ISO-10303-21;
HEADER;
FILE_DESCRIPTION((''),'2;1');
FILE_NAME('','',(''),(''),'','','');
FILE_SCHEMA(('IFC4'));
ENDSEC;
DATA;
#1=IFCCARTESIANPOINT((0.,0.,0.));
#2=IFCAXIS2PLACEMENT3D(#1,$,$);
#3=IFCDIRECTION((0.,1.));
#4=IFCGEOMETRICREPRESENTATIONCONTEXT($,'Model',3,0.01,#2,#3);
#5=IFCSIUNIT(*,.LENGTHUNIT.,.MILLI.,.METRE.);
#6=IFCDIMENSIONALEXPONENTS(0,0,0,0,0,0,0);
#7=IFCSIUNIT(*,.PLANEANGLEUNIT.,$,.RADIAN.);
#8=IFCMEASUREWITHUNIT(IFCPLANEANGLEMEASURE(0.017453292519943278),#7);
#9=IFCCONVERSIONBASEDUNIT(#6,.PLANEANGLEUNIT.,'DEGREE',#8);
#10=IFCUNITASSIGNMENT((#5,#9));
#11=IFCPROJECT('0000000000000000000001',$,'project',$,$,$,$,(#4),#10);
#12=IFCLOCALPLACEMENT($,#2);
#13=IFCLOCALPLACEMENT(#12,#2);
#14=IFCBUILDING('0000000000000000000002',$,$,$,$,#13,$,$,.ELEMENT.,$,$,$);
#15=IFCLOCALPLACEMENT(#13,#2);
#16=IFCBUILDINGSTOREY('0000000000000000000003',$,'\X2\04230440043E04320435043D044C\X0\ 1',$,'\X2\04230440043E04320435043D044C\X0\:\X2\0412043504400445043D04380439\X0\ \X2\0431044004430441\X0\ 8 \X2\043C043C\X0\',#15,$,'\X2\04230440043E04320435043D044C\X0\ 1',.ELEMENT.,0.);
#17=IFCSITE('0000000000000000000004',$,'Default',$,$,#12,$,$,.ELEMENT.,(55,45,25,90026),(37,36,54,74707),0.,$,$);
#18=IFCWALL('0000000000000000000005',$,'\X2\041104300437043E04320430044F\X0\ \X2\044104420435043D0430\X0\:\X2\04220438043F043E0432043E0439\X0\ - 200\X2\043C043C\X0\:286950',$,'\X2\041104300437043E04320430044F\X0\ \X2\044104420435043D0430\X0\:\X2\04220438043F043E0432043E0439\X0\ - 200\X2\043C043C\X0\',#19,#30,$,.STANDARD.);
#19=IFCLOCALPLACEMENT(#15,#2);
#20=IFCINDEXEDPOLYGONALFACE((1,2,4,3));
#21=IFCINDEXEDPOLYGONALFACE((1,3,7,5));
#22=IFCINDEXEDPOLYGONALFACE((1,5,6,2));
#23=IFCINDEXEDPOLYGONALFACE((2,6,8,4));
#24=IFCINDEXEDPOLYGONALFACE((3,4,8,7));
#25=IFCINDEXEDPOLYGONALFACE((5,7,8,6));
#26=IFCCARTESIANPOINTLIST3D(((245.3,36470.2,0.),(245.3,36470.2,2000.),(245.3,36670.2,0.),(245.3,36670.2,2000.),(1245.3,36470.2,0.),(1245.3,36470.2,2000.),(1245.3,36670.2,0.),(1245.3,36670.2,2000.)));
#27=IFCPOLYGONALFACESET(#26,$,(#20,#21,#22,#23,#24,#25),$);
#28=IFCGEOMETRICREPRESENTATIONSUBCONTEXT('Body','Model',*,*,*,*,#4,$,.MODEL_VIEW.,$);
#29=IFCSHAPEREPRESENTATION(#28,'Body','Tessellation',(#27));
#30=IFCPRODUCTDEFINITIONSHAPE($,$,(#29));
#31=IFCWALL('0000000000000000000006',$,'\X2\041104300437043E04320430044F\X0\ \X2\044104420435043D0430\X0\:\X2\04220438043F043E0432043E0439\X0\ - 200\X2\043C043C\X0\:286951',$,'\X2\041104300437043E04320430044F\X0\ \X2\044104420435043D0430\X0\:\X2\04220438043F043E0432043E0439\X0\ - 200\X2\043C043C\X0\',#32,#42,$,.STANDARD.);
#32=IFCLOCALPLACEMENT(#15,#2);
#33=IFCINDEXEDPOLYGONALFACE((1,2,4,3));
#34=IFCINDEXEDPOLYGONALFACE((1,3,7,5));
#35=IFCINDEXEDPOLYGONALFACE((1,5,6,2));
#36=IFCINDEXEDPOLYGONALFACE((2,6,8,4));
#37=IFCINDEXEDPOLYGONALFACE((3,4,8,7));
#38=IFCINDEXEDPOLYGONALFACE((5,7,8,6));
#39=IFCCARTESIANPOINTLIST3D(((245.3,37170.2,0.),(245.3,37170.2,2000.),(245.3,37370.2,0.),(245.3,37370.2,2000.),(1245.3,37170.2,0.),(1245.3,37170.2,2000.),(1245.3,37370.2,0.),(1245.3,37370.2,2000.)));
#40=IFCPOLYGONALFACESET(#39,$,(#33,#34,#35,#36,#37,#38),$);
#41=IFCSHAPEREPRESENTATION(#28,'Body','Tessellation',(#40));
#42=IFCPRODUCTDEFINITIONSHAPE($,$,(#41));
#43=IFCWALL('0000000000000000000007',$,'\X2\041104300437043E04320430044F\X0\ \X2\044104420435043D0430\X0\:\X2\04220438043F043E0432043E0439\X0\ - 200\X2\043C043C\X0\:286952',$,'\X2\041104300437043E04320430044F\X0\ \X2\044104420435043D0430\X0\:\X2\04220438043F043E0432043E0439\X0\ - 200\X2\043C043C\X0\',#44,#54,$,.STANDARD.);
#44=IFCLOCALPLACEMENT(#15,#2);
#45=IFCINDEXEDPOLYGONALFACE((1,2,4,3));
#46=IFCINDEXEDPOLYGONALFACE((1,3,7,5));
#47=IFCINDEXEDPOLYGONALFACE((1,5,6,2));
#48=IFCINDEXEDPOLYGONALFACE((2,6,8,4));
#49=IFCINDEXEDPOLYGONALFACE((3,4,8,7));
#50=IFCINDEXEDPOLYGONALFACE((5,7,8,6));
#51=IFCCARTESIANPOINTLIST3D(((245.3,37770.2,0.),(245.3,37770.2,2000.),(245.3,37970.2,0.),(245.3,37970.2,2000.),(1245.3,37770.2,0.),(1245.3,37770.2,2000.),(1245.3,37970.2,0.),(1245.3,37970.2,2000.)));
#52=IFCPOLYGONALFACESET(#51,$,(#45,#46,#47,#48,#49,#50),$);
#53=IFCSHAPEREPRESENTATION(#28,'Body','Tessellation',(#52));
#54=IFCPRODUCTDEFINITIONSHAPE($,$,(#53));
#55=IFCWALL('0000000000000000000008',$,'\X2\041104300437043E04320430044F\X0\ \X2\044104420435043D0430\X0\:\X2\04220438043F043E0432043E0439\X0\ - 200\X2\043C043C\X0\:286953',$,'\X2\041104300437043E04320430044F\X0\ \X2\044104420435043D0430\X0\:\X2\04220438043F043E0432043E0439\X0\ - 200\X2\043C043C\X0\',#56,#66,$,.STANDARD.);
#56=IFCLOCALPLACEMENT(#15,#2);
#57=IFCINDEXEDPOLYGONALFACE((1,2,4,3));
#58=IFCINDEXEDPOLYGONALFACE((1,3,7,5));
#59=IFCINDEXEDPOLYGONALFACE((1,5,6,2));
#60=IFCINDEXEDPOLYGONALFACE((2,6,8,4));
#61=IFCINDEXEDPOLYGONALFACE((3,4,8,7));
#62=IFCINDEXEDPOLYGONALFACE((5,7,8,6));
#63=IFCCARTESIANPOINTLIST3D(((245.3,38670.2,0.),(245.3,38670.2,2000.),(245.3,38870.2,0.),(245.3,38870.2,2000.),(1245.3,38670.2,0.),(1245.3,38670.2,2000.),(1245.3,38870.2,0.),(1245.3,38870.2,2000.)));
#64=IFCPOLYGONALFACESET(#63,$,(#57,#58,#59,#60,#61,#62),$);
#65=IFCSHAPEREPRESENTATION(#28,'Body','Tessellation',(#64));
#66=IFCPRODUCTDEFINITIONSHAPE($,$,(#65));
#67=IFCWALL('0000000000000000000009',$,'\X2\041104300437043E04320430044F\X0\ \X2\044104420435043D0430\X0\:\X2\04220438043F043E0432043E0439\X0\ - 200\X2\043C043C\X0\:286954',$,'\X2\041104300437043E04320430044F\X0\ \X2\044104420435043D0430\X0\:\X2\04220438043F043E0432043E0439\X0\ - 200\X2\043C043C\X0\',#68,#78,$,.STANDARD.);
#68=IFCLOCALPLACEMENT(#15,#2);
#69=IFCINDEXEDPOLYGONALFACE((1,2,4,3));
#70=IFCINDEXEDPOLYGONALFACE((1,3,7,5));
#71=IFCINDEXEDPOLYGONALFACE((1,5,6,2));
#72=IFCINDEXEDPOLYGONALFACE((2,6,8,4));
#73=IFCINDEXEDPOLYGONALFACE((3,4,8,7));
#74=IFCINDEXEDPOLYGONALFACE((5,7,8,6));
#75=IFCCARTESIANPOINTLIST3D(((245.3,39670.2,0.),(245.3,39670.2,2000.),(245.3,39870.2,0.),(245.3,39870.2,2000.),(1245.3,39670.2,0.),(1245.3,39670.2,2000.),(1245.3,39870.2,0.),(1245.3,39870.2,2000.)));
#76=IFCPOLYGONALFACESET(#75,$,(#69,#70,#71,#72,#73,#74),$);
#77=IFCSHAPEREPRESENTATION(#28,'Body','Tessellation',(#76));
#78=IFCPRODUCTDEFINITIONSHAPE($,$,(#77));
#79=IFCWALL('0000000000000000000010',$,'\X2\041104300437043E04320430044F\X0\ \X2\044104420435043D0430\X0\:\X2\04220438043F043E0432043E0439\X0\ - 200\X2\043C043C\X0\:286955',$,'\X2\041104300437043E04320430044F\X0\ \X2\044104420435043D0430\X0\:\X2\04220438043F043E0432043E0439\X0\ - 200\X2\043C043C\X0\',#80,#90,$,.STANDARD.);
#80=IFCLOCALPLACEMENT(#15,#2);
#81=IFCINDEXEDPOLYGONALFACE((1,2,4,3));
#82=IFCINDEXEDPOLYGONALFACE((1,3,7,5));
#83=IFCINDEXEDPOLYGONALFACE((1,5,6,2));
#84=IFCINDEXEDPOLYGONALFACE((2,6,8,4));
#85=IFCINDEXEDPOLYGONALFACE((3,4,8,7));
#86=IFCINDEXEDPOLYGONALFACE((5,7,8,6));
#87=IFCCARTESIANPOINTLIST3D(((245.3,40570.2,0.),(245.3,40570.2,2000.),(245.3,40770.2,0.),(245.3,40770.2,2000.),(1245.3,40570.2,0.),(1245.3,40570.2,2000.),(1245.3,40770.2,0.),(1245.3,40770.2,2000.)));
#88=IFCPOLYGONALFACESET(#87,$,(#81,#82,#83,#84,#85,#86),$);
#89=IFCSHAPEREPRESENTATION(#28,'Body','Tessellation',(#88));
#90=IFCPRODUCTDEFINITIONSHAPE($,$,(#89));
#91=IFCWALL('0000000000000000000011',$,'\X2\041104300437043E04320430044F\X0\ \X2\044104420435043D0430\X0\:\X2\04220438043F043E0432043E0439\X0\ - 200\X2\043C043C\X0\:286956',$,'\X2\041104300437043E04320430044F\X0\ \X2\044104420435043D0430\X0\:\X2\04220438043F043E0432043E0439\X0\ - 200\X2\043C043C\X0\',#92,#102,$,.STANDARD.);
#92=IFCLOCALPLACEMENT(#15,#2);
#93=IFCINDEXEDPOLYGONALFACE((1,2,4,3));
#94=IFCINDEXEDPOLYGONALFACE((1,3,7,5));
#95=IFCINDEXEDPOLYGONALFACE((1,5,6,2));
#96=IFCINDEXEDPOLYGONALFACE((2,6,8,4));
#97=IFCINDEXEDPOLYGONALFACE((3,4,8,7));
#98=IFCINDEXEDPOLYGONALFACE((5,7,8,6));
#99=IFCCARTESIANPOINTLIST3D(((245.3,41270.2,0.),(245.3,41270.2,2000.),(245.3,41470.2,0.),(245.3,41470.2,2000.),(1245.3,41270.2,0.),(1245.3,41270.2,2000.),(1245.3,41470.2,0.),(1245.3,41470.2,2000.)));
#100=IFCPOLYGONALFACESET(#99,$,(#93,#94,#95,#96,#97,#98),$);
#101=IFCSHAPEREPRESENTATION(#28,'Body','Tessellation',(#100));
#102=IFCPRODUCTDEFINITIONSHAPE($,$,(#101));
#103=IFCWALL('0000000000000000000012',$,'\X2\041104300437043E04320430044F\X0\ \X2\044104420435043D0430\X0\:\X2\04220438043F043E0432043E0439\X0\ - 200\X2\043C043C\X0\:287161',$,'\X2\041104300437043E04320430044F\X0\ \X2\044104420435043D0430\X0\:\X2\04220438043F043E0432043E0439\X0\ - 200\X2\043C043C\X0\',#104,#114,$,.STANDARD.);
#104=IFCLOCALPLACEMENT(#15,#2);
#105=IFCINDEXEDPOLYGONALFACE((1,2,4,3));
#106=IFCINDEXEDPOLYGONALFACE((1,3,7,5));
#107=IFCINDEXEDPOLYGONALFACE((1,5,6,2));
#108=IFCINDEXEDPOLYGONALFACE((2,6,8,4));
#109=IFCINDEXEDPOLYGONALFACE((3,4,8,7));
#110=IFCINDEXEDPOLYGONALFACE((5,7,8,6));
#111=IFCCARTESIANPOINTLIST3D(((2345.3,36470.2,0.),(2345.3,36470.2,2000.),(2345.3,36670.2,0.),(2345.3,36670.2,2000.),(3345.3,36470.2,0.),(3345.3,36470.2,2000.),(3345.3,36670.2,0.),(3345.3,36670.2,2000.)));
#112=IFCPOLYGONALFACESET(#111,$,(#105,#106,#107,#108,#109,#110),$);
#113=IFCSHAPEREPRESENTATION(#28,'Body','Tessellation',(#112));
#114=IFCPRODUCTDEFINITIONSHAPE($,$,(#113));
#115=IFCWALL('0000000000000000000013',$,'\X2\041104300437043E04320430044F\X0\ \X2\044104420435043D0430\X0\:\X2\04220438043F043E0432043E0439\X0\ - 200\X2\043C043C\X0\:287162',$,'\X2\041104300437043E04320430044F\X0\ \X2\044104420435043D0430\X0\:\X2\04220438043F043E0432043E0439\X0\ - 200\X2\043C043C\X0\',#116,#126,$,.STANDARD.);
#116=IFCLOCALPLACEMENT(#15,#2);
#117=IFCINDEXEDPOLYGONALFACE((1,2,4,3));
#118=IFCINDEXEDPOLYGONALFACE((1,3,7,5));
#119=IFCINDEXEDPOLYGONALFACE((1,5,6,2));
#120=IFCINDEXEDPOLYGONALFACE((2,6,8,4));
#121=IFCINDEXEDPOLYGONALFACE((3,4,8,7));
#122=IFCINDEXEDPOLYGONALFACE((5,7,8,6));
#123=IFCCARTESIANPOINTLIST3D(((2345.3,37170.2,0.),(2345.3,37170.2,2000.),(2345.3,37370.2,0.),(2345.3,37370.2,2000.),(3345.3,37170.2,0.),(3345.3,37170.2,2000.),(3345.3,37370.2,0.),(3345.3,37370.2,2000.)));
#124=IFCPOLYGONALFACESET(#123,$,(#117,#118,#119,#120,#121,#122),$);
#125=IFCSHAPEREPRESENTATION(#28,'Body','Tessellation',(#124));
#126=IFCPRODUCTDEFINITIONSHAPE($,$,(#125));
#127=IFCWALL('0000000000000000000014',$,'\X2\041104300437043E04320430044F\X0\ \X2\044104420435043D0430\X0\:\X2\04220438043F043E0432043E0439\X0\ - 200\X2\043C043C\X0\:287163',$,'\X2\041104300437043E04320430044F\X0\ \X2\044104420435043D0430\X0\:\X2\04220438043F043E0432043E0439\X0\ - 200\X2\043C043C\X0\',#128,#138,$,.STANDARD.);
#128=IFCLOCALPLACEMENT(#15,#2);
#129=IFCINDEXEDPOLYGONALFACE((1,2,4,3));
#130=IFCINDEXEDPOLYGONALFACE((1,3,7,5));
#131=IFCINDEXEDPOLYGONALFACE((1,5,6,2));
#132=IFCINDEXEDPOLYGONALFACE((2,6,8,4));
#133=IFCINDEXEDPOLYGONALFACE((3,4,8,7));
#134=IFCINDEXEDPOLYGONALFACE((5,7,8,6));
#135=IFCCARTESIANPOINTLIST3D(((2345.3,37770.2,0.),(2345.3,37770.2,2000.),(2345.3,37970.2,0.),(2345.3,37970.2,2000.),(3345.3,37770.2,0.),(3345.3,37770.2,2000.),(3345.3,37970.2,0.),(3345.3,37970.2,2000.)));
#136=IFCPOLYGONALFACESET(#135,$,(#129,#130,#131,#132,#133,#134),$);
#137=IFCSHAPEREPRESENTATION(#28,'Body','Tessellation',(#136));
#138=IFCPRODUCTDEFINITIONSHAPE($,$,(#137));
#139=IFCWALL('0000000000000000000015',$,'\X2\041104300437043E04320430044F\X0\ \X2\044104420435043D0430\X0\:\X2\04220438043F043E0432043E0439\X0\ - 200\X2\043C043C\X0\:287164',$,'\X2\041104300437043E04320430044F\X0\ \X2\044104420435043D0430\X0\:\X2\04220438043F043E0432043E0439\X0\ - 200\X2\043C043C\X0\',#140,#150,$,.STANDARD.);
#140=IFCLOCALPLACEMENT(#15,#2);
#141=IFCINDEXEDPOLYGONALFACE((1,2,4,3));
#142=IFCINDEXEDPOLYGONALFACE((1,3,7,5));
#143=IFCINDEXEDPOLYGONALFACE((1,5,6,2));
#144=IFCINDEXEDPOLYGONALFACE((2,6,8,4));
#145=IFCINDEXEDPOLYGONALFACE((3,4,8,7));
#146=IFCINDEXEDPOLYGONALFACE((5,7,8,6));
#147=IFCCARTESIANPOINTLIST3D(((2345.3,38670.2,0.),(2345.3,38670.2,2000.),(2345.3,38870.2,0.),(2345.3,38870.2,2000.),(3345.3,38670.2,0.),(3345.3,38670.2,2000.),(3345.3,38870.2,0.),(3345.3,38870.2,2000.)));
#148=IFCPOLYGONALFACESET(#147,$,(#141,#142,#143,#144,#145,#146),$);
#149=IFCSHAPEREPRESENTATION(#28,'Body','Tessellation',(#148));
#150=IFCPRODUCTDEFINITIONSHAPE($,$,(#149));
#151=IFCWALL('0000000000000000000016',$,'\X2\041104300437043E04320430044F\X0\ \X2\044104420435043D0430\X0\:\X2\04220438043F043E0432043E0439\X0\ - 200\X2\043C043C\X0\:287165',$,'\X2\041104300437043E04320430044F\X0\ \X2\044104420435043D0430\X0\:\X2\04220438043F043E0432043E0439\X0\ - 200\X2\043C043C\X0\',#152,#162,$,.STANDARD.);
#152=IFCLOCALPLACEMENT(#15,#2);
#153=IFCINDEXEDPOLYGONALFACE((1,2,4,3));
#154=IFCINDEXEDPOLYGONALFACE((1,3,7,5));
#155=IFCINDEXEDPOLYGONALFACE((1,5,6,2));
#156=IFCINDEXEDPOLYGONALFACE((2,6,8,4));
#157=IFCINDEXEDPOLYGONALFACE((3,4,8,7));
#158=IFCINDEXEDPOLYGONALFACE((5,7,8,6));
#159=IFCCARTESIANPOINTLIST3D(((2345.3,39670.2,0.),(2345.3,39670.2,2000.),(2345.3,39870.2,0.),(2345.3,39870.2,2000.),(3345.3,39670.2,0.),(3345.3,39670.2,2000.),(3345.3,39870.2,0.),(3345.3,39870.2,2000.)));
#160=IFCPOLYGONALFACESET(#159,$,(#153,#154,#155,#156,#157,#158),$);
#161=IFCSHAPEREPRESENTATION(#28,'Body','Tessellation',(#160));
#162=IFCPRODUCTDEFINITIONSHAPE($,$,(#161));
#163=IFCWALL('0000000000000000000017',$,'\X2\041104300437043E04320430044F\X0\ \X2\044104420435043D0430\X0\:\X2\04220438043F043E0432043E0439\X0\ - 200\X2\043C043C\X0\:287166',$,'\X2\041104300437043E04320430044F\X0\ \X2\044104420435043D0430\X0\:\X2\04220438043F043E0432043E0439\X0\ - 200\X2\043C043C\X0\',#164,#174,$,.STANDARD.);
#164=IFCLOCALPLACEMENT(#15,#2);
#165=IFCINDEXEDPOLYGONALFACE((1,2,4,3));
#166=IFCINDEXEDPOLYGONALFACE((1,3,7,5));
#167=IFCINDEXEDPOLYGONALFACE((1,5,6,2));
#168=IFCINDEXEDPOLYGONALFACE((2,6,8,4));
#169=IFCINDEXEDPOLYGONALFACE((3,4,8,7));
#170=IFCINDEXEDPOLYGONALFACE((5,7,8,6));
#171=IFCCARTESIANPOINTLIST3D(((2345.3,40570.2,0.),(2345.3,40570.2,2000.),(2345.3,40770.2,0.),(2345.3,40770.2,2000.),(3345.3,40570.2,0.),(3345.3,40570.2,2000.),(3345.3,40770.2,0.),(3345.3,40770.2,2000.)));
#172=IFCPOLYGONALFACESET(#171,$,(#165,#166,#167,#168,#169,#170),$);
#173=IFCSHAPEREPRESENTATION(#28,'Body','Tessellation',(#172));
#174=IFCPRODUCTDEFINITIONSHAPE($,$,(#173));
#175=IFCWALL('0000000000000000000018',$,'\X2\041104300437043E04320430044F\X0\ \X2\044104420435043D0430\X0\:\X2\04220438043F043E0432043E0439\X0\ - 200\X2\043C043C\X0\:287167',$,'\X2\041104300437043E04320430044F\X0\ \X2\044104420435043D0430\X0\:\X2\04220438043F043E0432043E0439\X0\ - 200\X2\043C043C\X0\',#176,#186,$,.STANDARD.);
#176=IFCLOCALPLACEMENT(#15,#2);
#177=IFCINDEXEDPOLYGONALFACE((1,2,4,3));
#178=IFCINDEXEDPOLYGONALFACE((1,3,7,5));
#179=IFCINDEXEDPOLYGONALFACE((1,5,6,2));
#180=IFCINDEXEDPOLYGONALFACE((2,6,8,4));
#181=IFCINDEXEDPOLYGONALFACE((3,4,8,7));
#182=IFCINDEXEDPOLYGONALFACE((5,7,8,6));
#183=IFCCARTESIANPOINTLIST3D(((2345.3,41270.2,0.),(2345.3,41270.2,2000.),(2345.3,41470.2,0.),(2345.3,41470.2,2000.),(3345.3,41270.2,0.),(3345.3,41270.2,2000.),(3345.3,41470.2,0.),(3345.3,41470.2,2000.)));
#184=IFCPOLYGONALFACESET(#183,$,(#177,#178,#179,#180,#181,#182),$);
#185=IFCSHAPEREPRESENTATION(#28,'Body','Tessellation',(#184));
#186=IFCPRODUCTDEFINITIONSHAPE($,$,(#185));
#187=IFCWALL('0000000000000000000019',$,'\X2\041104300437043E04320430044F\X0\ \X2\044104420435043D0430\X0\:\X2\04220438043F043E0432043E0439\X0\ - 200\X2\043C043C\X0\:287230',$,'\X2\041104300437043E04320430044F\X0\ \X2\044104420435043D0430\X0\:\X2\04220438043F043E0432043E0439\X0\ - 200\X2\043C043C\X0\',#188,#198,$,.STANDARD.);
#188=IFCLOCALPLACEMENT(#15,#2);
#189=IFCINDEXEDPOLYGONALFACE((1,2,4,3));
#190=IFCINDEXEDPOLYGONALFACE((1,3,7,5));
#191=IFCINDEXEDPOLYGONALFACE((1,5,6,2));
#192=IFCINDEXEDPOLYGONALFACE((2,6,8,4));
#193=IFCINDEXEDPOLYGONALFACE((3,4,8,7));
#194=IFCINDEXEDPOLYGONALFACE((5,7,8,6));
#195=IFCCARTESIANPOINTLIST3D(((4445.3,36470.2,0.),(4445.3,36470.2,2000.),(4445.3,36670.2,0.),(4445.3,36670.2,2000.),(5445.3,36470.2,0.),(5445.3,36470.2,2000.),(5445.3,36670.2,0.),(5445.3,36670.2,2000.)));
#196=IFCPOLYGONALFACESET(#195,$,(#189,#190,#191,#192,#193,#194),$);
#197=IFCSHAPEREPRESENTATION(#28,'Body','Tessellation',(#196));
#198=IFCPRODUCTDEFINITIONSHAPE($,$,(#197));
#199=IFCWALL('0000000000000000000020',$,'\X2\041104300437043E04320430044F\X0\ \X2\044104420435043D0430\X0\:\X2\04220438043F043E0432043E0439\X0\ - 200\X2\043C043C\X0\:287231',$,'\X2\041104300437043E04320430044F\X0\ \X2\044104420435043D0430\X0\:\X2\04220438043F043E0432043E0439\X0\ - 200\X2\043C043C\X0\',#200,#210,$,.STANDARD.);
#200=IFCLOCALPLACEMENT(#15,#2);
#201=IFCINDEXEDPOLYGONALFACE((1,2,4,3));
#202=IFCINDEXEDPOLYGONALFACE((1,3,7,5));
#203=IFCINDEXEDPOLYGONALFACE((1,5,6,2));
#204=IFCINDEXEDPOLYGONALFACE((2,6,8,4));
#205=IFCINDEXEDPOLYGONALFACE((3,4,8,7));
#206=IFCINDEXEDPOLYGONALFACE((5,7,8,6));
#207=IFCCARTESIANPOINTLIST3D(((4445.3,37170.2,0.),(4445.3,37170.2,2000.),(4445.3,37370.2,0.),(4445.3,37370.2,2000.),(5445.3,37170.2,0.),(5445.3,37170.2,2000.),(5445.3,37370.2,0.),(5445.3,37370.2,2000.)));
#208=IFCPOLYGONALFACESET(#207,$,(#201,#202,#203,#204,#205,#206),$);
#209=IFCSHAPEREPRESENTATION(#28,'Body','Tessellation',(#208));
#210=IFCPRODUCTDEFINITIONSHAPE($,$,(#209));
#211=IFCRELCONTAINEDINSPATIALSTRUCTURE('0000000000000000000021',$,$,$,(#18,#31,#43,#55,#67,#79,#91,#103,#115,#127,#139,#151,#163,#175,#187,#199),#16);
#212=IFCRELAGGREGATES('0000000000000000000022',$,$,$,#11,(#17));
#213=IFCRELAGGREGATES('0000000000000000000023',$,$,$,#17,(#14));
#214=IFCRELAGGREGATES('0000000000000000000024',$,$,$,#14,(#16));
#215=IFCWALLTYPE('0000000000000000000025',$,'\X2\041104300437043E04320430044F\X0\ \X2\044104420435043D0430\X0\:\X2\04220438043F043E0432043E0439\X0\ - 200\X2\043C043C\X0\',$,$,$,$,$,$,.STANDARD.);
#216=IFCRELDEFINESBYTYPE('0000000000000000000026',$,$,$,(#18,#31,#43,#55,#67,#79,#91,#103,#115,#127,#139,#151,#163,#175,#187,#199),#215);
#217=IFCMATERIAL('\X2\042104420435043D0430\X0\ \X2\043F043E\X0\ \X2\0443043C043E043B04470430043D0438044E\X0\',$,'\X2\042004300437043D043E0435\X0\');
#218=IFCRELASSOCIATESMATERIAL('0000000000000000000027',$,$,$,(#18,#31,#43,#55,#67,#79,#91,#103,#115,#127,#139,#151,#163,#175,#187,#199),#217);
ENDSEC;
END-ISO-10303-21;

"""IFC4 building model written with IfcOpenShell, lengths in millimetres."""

from ifc_helpers import new_model, entity, si_unit, converted_unit, direction, frame, origin, place, context, subcontext, project, spatial, indexed_curve, outline, extrude, material, type_object, element, save


model = new_model("IFC4")

# Units and contexts
model_context = context("Model", 3, precision=0.01, world=origin(), true_north=direction((0.0, 1.0)))
body_context = subcontext(model_context, "Body", "Model", "MODEL_VIEW")
ifc_project = project(units=[si_unit("LENGTHUNIT", "METRE", prefix="MILLI"), converted_unit("PLANEANGLEUNIT", "DEGREE", entity("IfcPlaneAngleMeasure", 0.017453292519943278), si_unit("PLANEANGLEUNIT", "RADIAN"), dimensions=[0, 0, 0, 0, 0, 0, 0])], contexts=[model_context])

# Site, building, storey
site_placement = place(None, origin())
site = spatial("IfcSite", under=ifc_project, at=site_placement, Name="Default", CompositionType="ELEMENT", RefLatitude=(55, 45, 25, 90026), RefLongitude=(37, 36, 54, 74707), RefElevation=0.0)
building_placement = place(site_placement, origin())
building = spatial("IfcBuilding", under=site, at=building_placement, CompositionType="ELEMENT")
storey_placement = place(building_placement, origin())
storey = spatial("IfcBuildingStorey", under=building, at=storey_placement, Name="Уровень 1", ObjectType="Уровень:Верхний брус 8 мм", LongName="Уровень 1", CompositionType="ELEMENT", Elevation=0.0)

# Walls
ifc_material = material(Name="Стена по умолчанию", Category="Разное")
wall_type = type_object("IfcWallType", Name="Базовая стена:Типовой - 200мм", PredefinedType="STANDARD")
for number, where, name in (
    (1, (245.3, 36570.2, 0.0), "Базовая стена:Типовой - 200мм:286950"),
    (2, (245.3, 37270.2, 0.0), "Базовая стена:Типовой - 200мм:286951"),
):
    element("IfcWall", number, at=place(storey_placement, frame(where)), inside=storey, type_object=wall_type, material=ifc_material, Name=name, ObjectType="Базовая стена:Типовой - 200мм", PredefinedType="STANDARD", context=body_context, shape_type="SweptSolid", body=[
        extrude(outline(indexed_curve([(1000.0, 100.0), (0.0, 100.0), (0.0, -100.0), (1000.0, -100.0), (1000.0, 100.0)], self_intersect=False)), origin(), (0.0, 0.0, 1.0), 2000.0),
    ])
for number, where, name in (
    (3, (245.3, 37870.2, 0.0), "Базовая стена:Типовой - 200мм:286952"),
    (4, (245.3, 38770.2, 0.0), "Базовая стена:Типовой - 200мм:286953"),
):
    element("IfcWall", number, at=place(storey_placement, frame(where)), inside=storey, type_object=wall_type, material=ifc_material, Name=name, ObjectType="Базовая стена:Типовой - 200мм", PredefinedType="STANDARD", context=body_context, shape_type="SweptSolid", body=[
        extrude(outline(indexed_curve([(1000.0, 100.0), (0.0, 100.0), (0.0, -100.0), (1000.0, -100.0), (1000.0, 100.0)], self_intersect=False)), origin(), (0.0, 0.0, 1.0), 2000.0),
    ])
wall_1_placement = place(storey_placement, frame((245.3, 39770.2, 0.0)))
element("IfcWall", 5, at=wall_1_placement, inside=storey, type_object=wall_type, material=ifc_material, Name="Базовая стена:Типовой - 200мм:286954", ObjectType="Базовая стена:Типовой - 200мм", PredefinedType="STANDARD", context=body_context, shape_type="SweptSolid", body=[
    extrude(outline(indexed_curve([(1000.0, 100.0), (0.0, 100.0), (0.0, -100.0), (1000.0, -100.0), (1000.0, 100.0)], self_intersect=False)), origin(), (0.0, 0.0, 1.0), 2000.0),
])
for number, where, name in (
    (6, (245.3, 40670.2, 0.0), "Базовая стена:Типовой - 200мм:286955"),
    (7, (245.3, 41370.2, 0.0), "Базовая стена:Типовой - 200мм:286956"),
):
    element("IfcWall", number, at=place(storey_placement, frame(where)), inside=storey, type_object=wall_type, material=ifc_material, Name=name, ObjectType="Базовая стена:Типовой - 200мм", PredefinedType="STANDARD", context=body_context, shape_type="SweptSolid", body=[
        extrude(outline(indexed_curve([(1000.0, 100.0), (0.0, 100.0), (0.0, -100.0), (1000.0, -100.0), (1000.0, 100.0)], self_intersect=False)), origin(), (0.0, 0.0, 1.0), 2000.0),
    ])
for number, where, name in (
    (8, (2345.3, 36570.2, 0.0), "Базовая стена:Типовой - 200мм:287161"),
    (9, (2345.3, 37270.2, 0.0), "Базовая стена:Типовой - 200мм:287162"),
):
    element("IfcWall", number, at=place(storey_placement, frame(where)), inside=storey, type_object=wall_type, material=ifc_material, Name=name, ObjectType="Базовая стена:Типовой - 200мм", PredefinedType="STANDARD", context=body_context, shape_type="SweptSolid", body=[
        extrude(outline(indexed_curve([(1000.0, 100.0), (0.0, 100.0), (0.0, -100.0), (1000.0, -100.0), (1000.0, 100.0)], self_intersect=False)), origin(), (0.0, 0.0, 1.0), 2000.0),
    ])
for number, where, name in (
    (10, (2345.3, 37870.2, 0.0), "Базовая стена:Типовой - 200мм:287163"),
    (11, (2345.3, 38770.2, 0.0), "Базовая стена:Типовой - 200мм:287164"),
):
    element("IfcWall", number, at=place(storey_placement, frame(where)), inside=storey, type_object=wall_type, material=ifc_material, Name=name, ObjectType="Базовая стена:Типовой - 200мм", PredefinedType="STANDARD", context=body_context, shape_type="SweptSolid", body=[
        extrude(outline(indexed_curve([(1000.0, 100.0), (0.0, 100.0), (0.0, -100.0), (1000.0, -100.0), (1000.0, 100.0)], self_intersect=False)), origin(), (0.0, 0.0, 1.0), 2000.0),
    ])
wall_2_placement = place(storey_placement, frame((2345.3, 39770.2, 0.0)))
element("IfcWall", 12, at=wall_2_placement, inside=storey, type_object=wall_type, material=ifc_material, Name="Базовая стена:Типовой - 200мм:287165", ObjectType="Базовая стена:Типовой - 200мм", PredefinedType="STANDARD", context=body_context, shape_type="SweptSolid", body=[
    extrude(outline(indexed_curve([(1000.0, 100.0), (0.0, 100.0), (0.0, -100.0), (1000.0, -100.0), (1000.0, 100.0)], self_intersect=False)), origin(), (0.0, 0.0, 1.0), 2000.0),
])
for number, where, name in (
    (13, (2345.3, 40670.2, 0.0), "Базовая стена:Типовой - 200мм:287166"),
    (14, (2345.3, 41370.2, 0.0), "Базовая стена:Типовой - 200мм:287167"),
):
    element("IfcWall", number, at=place(storey_placement, frame(where)), inside=storey, type_object=wall_type, material=ifc_material, Name=name, ObjectType="Базовая стена:Типовой - 200мм", PredefinedType="STANDARD", context=body_context, shape_type="SweptSolid", body=[
        extrude(outline(indexed_curve([(1000.0, 100.0), (0.0, 100.0), (0.0, -100.0), (1000.0, -100.0), (1000.0, 100.0)], self_intersect=False)), origin(), (0.0, 0.0, 1.0), 2000.0),
    ])
for number, where, name in (
    (15, (4445.3, 36570.2, 0.0), "Базовая стена:Типовой - 200мм:287230"),
    (16, (4445.3, 37270.2, 0.0), "Базовая стена:Типовой - 200мм:287231"),
):
    element("IfcWall", number, at=place(storey_placement, frame(where)), inside=storey, type_object=wall_type, material=ifc_material, Name=name, ObjectType="Базовая стена:Типовой - 200мм", PredefinedType="STANDARD", context=body_context, shape_type="SweptSolid", body=[
        extrude(outline(indexed_curve([(1000.0, 100.0), (0.0, 100.0), (0.0, -100.0), (1000.0, -100.0), (1000.0, 100.0)], self_intersect=False)), origin(), (0.0, 0.0, 1.0), 2000.0),
    ])

save(model, "model.ifc")
